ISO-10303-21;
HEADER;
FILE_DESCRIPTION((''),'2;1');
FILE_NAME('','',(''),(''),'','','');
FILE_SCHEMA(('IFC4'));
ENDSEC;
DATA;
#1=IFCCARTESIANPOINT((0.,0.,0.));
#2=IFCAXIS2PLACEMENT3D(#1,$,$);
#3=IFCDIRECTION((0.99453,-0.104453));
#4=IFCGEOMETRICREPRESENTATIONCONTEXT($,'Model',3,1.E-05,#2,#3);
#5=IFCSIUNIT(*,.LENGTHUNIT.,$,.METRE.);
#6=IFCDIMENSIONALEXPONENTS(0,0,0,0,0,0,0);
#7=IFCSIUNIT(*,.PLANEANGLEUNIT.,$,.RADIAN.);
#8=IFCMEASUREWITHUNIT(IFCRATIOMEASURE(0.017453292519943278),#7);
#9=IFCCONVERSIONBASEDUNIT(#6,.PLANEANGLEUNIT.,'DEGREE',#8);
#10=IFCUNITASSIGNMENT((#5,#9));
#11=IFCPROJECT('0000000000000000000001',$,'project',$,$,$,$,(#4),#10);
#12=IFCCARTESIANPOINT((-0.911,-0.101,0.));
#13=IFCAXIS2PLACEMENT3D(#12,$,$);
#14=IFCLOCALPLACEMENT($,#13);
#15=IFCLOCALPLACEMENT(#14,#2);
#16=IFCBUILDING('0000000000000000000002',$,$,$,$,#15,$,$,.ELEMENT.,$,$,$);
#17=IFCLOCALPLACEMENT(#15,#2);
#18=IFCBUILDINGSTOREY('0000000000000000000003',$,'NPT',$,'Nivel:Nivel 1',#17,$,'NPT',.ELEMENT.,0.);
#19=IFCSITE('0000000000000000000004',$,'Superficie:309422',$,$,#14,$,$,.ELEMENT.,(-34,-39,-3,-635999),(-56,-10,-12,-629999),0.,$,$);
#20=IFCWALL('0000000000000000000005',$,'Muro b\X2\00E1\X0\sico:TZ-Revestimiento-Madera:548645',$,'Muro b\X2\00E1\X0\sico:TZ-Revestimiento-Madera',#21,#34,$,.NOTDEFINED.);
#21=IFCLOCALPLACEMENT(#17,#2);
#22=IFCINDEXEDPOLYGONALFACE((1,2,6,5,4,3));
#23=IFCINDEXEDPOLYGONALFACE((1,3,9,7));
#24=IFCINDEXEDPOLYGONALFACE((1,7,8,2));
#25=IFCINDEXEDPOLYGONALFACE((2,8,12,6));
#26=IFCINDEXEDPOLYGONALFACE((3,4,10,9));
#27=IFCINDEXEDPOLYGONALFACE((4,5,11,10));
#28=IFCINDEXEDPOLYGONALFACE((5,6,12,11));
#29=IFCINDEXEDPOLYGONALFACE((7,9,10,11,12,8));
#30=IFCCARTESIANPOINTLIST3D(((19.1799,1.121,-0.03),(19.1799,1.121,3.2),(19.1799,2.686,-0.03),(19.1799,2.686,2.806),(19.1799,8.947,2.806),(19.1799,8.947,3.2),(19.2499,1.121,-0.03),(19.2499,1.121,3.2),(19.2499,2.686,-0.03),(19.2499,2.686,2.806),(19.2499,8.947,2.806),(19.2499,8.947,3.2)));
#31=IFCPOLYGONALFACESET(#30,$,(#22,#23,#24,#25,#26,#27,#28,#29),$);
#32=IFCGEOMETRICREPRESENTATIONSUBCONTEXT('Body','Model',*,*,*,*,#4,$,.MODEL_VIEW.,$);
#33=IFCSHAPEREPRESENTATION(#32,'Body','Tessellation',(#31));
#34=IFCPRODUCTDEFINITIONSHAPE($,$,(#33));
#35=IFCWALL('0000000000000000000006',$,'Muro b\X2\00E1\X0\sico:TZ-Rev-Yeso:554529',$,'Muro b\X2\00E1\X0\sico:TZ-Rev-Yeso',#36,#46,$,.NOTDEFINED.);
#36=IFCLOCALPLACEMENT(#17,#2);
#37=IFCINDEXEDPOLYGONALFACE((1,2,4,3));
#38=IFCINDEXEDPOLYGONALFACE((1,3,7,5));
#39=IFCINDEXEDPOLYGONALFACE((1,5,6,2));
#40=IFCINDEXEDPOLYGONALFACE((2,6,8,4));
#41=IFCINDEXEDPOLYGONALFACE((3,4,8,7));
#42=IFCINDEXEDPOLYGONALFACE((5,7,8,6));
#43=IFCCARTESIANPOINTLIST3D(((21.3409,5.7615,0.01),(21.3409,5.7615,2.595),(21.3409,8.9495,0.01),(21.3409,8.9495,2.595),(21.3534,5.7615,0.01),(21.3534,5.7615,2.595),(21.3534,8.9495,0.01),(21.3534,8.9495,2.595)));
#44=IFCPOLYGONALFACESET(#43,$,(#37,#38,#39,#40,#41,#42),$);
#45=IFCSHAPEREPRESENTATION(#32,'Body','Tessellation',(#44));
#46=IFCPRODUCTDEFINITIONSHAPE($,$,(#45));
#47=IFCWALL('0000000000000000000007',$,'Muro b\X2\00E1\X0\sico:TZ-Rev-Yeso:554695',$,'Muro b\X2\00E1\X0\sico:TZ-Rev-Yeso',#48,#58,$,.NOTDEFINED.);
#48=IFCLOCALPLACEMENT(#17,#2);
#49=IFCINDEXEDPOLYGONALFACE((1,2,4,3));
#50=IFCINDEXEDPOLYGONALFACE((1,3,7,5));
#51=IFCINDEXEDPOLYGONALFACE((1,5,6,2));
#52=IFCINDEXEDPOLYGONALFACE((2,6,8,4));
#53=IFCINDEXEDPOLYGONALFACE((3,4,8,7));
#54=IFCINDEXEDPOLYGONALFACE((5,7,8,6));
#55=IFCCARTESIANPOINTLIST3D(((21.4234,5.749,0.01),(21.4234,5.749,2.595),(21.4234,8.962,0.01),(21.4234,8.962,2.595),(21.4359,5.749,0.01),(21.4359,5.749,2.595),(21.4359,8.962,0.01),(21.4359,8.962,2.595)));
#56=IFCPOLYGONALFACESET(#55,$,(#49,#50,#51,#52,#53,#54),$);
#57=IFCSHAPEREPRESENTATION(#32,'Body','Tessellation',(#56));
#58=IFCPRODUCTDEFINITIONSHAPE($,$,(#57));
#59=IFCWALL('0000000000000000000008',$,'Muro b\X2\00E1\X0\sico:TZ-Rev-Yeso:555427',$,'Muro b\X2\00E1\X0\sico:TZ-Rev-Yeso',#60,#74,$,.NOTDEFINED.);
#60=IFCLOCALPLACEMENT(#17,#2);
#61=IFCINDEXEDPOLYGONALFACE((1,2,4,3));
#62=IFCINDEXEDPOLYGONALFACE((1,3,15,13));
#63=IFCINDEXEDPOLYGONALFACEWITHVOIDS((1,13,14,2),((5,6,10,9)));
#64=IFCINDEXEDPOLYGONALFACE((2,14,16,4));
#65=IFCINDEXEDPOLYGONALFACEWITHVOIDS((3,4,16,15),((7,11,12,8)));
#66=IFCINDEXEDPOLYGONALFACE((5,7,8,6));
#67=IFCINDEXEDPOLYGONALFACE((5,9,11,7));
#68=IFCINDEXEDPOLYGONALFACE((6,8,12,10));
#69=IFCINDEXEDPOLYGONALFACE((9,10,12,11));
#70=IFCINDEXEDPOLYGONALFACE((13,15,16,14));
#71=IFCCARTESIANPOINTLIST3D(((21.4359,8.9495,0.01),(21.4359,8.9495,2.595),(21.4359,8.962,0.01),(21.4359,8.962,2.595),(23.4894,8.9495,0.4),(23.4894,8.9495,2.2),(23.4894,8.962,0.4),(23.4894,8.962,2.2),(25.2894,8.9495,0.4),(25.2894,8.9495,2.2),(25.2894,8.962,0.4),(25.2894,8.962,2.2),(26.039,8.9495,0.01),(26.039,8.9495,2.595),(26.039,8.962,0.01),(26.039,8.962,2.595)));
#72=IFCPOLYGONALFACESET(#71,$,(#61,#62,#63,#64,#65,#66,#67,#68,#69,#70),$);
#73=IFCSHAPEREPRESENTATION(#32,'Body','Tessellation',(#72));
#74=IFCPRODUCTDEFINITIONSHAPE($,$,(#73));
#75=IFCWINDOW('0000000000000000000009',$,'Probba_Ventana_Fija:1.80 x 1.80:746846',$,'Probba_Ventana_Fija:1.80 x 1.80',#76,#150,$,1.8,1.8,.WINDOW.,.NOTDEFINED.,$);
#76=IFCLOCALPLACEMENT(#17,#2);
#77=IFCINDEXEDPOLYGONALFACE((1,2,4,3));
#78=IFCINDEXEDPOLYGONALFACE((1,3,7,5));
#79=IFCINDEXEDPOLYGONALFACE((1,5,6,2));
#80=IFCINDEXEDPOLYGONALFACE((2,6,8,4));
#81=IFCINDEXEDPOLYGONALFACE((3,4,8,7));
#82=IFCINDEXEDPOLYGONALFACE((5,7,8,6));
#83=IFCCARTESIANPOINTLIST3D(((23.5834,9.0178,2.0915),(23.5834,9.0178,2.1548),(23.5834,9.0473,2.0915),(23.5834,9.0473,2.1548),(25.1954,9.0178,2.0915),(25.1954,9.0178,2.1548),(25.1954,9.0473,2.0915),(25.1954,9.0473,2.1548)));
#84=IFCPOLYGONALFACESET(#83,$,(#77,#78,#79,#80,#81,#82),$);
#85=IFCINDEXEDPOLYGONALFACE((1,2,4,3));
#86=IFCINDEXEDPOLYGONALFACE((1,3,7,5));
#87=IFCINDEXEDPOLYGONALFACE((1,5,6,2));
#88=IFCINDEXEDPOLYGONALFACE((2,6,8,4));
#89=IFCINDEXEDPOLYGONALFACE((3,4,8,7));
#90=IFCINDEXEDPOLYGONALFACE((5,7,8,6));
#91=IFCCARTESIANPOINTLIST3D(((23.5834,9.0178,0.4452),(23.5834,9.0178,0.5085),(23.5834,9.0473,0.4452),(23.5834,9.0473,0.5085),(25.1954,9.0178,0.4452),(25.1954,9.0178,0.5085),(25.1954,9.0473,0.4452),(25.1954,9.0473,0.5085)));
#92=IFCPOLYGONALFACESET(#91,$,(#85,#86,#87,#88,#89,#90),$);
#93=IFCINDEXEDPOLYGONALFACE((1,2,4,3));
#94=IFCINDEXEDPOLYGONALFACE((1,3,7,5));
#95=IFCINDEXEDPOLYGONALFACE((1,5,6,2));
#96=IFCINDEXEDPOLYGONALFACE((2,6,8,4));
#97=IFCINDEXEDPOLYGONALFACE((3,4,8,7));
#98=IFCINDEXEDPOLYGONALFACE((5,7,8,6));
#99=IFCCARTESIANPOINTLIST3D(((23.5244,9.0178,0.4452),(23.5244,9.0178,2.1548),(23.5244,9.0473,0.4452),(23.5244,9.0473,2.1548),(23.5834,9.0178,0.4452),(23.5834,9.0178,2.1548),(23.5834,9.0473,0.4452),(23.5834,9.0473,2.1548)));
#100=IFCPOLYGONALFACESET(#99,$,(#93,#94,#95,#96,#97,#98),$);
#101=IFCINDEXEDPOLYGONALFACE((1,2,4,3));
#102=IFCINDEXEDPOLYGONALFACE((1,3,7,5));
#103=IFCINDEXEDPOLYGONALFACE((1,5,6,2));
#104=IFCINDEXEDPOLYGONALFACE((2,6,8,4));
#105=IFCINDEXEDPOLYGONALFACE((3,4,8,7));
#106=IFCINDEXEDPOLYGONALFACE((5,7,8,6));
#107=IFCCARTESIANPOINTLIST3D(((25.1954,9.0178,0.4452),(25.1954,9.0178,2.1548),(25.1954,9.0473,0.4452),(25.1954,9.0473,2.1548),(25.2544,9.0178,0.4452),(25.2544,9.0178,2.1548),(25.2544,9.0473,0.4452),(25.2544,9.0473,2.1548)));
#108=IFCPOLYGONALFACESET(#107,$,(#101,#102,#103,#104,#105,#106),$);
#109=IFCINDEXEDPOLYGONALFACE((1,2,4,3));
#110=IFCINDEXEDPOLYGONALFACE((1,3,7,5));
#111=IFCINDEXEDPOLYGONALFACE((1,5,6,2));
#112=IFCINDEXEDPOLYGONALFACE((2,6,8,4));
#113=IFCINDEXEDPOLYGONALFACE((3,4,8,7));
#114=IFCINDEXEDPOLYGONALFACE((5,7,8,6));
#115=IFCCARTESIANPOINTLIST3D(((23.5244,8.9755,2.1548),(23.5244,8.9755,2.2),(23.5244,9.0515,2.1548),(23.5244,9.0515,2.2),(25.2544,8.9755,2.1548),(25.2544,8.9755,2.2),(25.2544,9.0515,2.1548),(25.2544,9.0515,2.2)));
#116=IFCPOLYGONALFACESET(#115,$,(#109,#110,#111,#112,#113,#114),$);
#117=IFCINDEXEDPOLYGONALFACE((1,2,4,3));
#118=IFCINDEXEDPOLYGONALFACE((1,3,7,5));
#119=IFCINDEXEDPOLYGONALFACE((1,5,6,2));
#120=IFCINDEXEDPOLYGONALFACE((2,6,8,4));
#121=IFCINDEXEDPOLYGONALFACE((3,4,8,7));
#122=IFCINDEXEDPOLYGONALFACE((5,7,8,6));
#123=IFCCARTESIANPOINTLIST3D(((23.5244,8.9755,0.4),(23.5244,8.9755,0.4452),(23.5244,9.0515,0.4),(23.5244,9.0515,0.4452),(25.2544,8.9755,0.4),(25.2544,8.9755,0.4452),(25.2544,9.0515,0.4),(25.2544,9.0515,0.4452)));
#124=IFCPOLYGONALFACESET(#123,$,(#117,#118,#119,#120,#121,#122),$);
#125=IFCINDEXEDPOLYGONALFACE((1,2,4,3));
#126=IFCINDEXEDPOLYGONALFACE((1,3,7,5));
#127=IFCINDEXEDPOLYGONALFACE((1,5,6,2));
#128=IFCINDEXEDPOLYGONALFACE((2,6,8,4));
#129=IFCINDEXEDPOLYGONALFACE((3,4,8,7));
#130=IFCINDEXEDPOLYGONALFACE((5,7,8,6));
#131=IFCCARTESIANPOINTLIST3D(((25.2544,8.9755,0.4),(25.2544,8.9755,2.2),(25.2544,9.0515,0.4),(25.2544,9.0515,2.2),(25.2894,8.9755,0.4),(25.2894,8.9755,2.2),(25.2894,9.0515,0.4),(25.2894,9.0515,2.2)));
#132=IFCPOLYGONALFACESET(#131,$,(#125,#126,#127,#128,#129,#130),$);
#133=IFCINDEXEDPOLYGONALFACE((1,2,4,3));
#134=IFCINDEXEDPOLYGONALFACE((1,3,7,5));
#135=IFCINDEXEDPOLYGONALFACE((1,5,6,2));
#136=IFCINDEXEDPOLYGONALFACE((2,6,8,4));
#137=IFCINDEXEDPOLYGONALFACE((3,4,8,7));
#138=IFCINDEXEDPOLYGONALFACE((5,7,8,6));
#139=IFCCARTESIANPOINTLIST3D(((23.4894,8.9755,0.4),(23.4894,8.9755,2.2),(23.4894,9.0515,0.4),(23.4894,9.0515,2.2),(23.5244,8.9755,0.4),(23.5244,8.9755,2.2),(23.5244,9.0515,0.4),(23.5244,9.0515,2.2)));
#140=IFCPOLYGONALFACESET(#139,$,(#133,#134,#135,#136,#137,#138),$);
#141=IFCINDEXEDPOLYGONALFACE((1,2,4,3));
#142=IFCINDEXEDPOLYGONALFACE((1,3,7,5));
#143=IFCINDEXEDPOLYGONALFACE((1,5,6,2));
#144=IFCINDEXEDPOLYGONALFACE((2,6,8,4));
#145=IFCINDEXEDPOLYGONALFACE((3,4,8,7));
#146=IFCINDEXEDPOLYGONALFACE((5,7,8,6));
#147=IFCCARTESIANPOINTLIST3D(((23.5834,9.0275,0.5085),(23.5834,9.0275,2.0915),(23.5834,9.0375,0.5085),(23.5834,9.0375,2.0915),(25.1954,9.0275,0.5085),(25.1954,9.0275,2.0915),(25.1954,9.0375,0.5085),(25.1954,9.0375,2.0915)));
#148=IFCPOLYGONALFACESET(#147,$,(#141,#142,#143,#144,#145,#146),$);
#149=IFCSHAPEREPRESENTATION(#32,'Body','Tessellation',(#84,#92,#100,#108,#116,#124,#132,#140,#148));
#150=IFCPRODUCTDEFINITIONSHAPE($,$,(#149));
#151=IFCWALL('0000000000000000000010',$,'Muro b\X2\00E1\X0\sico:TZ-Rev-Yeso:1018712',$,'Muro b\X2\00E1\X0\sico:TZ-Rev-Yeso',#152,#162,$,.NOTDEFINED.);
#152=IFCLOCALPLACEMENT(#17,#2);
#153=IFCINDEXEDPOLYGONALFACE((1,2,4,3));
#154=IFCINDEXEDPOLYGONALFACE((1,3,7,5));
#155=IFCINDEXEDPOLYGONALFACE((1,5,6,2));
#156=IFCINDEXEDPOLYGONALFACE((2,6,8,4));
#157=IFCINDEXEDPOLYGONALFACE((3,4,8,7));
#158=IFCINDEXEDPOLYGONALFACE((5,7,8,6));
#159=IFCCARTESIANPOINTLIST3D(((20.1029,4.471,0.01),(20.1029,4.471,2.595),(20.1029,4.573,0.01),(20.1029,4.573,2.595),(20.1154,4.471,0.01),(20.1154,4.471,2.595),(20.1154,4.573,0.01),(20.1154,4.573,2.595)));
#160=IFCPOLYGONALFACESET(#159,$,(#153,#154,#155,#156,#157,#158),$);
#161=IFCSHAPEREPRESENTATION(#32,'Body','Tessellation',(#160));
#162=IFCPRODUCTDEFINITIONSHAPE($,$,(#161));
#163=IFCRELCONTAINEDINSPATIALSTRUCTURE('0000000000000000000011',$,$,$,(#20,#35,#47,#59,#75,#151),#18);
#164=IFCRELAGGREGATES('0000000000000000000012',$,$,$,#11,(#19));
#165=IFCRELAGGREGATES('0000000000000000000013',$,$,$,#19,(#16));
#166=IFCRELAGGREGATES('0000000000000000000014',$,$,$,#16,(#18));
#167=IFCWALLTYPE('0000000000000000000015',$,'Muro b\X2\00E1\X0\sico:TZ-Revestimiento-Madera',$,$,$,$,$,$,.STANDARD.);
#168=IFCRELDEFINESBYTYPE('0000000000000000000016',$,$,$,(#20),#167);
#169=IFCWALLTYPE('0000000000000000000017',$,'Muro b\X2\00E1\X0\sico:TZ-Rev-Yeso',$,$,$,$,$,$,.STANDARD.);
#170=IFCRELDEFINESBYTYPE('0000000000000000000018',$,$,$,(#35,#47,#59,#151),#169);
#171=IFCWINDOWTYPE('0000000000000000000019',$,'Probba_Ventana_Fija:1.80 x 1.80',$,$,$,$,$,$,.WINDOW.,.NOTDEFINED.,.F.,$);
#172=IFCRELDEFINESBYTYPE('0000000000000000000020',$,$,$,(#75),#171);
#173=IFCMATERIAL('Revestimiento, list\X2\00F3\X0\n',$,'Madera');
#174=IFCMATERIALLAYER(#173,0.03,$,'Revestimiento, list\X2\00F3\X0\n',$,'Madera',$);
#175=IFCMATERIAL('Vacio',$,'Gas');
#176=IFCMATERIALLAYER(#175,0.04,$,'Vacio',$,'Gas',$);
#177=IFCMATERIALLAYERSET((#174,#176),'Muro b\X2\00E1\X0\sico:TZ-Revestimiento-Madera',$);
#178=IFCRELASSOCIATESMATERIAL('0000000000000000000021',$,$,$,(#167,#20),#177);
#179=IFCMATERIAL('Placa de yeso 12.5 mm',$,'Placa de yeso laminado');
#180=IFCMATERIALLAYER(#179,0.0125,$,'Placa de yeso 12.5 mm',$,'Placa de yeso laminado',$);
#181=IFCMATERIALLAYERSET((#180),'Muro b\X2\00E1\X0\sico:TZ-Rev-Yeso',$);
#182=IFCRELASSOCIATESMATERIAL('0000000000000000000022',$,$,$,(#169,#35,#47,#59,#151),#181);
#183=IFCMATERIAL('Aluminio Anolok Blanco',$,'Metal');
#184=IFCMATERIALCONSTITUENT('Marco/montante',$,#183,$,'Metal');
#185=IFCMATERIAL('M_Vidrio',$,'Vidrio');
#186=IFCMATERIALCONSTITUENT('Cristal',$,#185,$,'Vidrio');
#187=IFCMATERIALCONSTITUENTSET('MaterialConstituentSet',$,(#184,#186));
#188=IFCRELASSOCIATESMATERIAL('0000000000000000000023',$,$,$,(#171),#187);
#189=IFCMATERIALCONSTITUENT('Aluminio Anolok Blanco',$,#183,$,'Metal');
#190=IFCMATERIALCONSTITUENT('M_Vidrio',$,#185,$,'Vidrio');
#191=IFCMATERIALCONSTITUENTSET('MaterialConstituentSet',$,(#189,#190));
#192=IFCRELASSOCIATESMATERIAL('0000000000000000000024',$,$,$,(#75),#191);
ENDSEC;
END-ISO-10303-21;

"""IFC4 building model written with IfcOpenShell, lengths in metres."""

from ifc_helpers import new_model, entity, si_unit, converted_unit, direction, frame, frame_2d, origin, origin_2d_with_axis, place, context, subcontext, project, spatial, rectangle, extrude, source, transform, mapped, material, layer, layer_set, layer_usage, constituent, constituent_set, type_object, type_shapes, element, fill, save


model = new_model("IFC4")

# Units and contexts
model_context = context("Model", 3, precision=1e-05, world=origin(), true_north=direction((0.99453, -0.104453)))
body_context = subcontext(model_context, "Body", "Model", "MODEL_VIEW")
ifc_project = project(units=[si_unit("LENGTHUNIT", "METRE"), converted_unit("PLANEANGLEUNIT", "DEGREE", entity("IfcRatioMeasure", 0.017453292519943278), si_unit("PLANEANGLEUNIT", "RADIAN"), dimensions=[0, 0, 0, 0, 0, 0, 0])], contexts=[model_context])

# Site, building, storey
site_placement = place(None, frame((-0.911, -0.101, 0.0)))
site = spatial("IfcSite", under=ifc_project, at=site_placement, Name="Superficie:309422", CompositionType="ELEMENT", RefLatitude=(-34, -39, -3, -635999), RefLongitude=(-56, -10, -12, -629999), RefElevation=0.0)
building_placement = place(site_placement, origin())
building = spatial("IfcBuilding", under=site, at=building_placement, CompositionType="ELEMENT")
storey_placement = place(building_placement, origin())
storey = spatial("IfcBuildingStorey", under=building, at=storey_placement, Name="NPT", ObjectType="Nivel:Nivel 1", LongName="NPT", CompositionType="ELEMENT", Elevation=0.0)

# Wall, opening
ifc_material_1 = material(Name="Revestimiento, listón", Category="Madera")
ifc_layer_1 = layer(ifc_material_1, 0.03, Name="Revestimiento, listón", Category="Madera")
ifc_material_2 = material(Name="Vacio", Category="Gas")
ifc_layer_2 = layer(ifc_material_2, 0.04, Name="Vacio", Category="Gas")
ifc_layer_set_1 = layer_set([ifc_layer_1, ifc_layer_2], Name="Muro básico:TZ-Revestimiento-Madera")
ifc_layer_usage_1 = layer_usage(ifc_layer_set_1, "AXIS2", "NEGATIVE", 0.035)
wall_type_1 = type_object("IfcWallType", Name="Muro básico:TZ-Revestimiento-Madera", PredefinedType="STANDARD", material=ifc_layer_set_1)
wall_1_placement = place(storey_placement, frame((19.2149, 8.947, -0.03), z_axis=(0.0, 0.0, 1.0), x_axis=(0.0, -1.0, 0.0)))
wall_1 = element("IfcWall", 1, at=wall_1_placement, inside=storey, type_object=wall_type_1, material=ifc_layer_usage_1, Name="Muro básico:TZ-Revestimiento-Madera:548645", ObjectType="Muro básico:TZ-Revestimiento-Madera", PredefinedType="NOTDEFINED", context=body_context, shape_type="SweptSolid", body=[
    extrude(rectangle(XDim=7.826, YDim=0.07, at=frame_2d((3.913, 0.0), x_axis=(-1.0, 0.0))), origin(), (0.0, 0.0, 1.0), 3.23),
])
opening_1_placement = place(wall_1_placement, origin())
element("IfcOpeningElement", 2, at=opening_1_placement, cuts=wall_1, PredefinedType="OPENING", context=body_context, shape_type="SweptSolid", body=[
    extrude(rectangle(XDim=2.836, YDim=6.2685, at=frame_2d((0.0, 0.0), x_axis=(1.0, 0.0))), frame((3.1268, 0.035, 1.418), z_axis=(0.0, -1.0, 0.0), x_axis=(0.0, 0.0, -1.0)), (0.0, 0.0, 1.0), 0.07),
])

# Walls
ifc_material_3 = material(Name="Placa de yeso 12.5 mm", Category="Placa de yeso laminado")
ifc_layer_3 = layer(ifc_material_3, 0.0125, Name="Placa de yeso 12.5 mm", Category="Placa de yeso laminado")
ifc_layer_set_2 = layer_set([ifc_layer_3], Name="Muro básico:TZ-Rev-Yeso")
ifc_layer_usage_2 = layer_usage(ifc_layer_set_2, "AXIS2", "POSITIVE", -0.0063)
wall_type_2 = type_object("IfcWallType", Name="Muro básico:TZ-Rev-Yeso", PredefinedType="STANDARD", material=ifc_layer_set_2)
wall_2_placement = place(storey_placement, frame((21.3471, 5.7615, 0.01), z_axis=(0.0, 0.0, 1.0), x_axis=(0.0, 1.0, 0.0)))
element("IfcWall", 3, at=wall_2_placement, inside=storey, type_object=wall_type_2, material=ifc_layer_usage_2, Name="Muro básico:TZ-Rev-Yeso:554529", ObjectType="Muro básico:TZ-Rev-Yeso", PredefinedType="NOTDEFINED", context=body_context, shape_type="SweptSolid", body=[
    extrude(rectangle(XDim=3.188, YDim=0.0125, at=frame_2d((1.594, 0.0), x_axis=(-1.0, 0.0))), origin(), (0.0, 0.0, 1.0), 2.585),
])
ifc_layer_usage_3 = layer_usage(ifc_layer_set_2, "AXIS2", "POSITIVE", -0.0063)
wall_3_placement = place(storey_placement, frame((21.4296, 8.962, 0.01), z_axis=(0.0, 0.0, 1.0), x_axis=(0.0, -1.0, 0.0)))
element("IfcWall", 4, at=wall_3_placement, inside=storey, type_object=wall_type_2, material=ifc_layer_usage_3, Name="Muro básico:TZ-Rev-Yeso:554695", ObjectType="Muro básico:TZ-Rev-Yeso", PredefinedType="NOTDEFINED", context=body_context, shape_type="SweptSolid", body=[
    extrude(rectangle(XDim=3.213, YDim=0.0125, at=frame_2d((1.6065, 0.0), x_axis=(-1.0, 0.0))), origin(), (0.0, 0.0, 1.0), 2.585),
])

# Wall, opening, window
ifc_layer_usage_4 = layer_usage(ifc_layer_set_2, "AXIS2", "NEGATIVE", 0.0063)
wall_4_placement = place(storey_placement, frame((21.4359, 8.9558, 0.01)))
wall_4 = element("IfcWall", 5, at=wall_4_placement, inside=storey, type_object=wall_type_2, material=ifc_layer_usage_4, Name="Muro básico:TZ-Rev-Yeso:555427", ObjectType="Muro básico:TZ-Rev-Yeso", PredefinedType="NOTDEFINED", context=body_context, shape_type="SweptSolid", body=[
    extrude(rectangle(XDim=4.6031, YDim=0.0125, at=frame_2d((2.3015, 0.0), x_axis=(-1.0, 0.0))), origin(), (0.0, 0.0, 1.0), 2.585),
])
opening_2_placement = place(wall_4_placement, frame((3.8535, 0.0063, 0.39)))
opening_2 = element("IfcOpeningElement", 6, at=opening_2_placement, cuts=wall_4, PredefinedType="OPENING", context=body_context, shape_type="SweptSolid", body=[
    extrude(rectangle(XDim=1.8, YDim=1.8, at=frame_2d((0.9, 0.9), x_axis=(1.0, 0.0))), frame((0.0, 0.0, 0.0), z_axis=(0.0, -1.0, 0.0), x_axis=(0.0, 0.0, 1.0)), (0.0, 0.0, 1.0), 0.0125),
])
ifc_material_4 = material(Name="Aluminio Anolok Blanco", Category="Metal")
ifc_constituent_1 = constituent(ifc_material_4, Name="Aluminio Anolok Blanco", Category="Metal")
ifc_material_5 = material(Name="M_Vidrio", Category="Vidrio")
ifc_constituent_2 = constituent(ifc_material_5, Name="M_Vidrio", Category="Vidrio")
ifc_constituent_set_1 = constituent_set(constituents=[ifc_constituent_1, ifc_constituent_2], Name="MaterialConstituentSet")
ifc_constituent_3 = constituent(ifc_material_4, Name="Marco/montante", Category="Metal")
ifc_constituent_4 = constituent(ifc_material_5, Name="Cristal", Category="Vidrio")
ifc_constituent_set_2 = constituent_set(constituents=[ifc_constituent_3, ifc_constituent_4], Name="MaterialConstituentSet")
window_type = type_object("IfcWindowType", Name="Probba_Ventana_Fija:1.80 x 1.80", ParameterTakesPrecedence=False, PartitioningType="NOTDEFINED", PredefinedType="WINDOW", material=ifc_constituent_set_2)
shared_shape_1 = source(origin(), body_context, "Body", "SweptSolid", [
    extrude(rectangle(XDim=1.612, YDim=0.0295, at=origin_2d_with_axis()), frame((0.9, -0.0705, 1.6915)), (0.0, 0.0, 1.0), 0.0633),
    extrude(rectangle(XDim=1.612, YDim=0.0295, at=origin_2d_with_axis()), frame((0.9, -0.0705, 0.0452)), (0.0, 0.0, 1.0), 0.0633),
    extrude(rectangle(XDim=0.0295, YDim=0.059, at=origin_2d_with_axis()), frame((1.7355, -0.0705, 0.0452), z_axis=(0.0, 0.0, 1.0), x_axis=(0.0, 1.0, 0.0)), (0.0, 0.0, 1.0), 1.7096),
    extrude(rectangle(XDim=0.0295, YDim=0.059, at=frame_2d((0.0, 0.0), x_axis=(1.0, 0.0))), frame((0.0645, -0.0705, 0.0452), z_axis=(0.0, 0.0, 1.0), x_axis=(0.0, 1.0, 0.0)), (0.0, 0.0, 1.0), 1.7096),
    extrude(rectangle(XDim=1.73, YDim=0.076, at=origin_2d_with_axis()), frame((0.9, -0.0515, 1.7548)), (0.0, 0.0, 1.0), 0.0452),
    extrude(rectangle(XDim=1.73, YDim=0.076, at=frame_2d((0.0, 0.0), x_axis=(1.0, 0.0))), frame((0.9, -0.0515, 0.0)), (0.0, 0.0, 1.0), 0.0452),
    extrude(rectangle(XDim=0.035, YDim=0.076, at=origin_2d_with_axis()), frame((0.0175, -0.0515, 0.0), z_axis=(0.0, 0.0, 1.0), x_axis=(-1.0, 0.0, 0.0)), (0.0, 0.0, 1.0), 1.8),
    extrude(rectangle(XDim=0.035, YDim=0.076, at=origin_2d_with_axis()), frame((1.7825, -0.0515, 0.0), z_axis=(0.0, 0.0, 1.0), x_axis=(-1.0, 0.0, 0.0)), (0.0, 0.0, 1.0), 1.8),
    extrude(rectangle(XDim=0.01, YDim=1.612, at=origin_2d_with_axis()), frame((0.9, -0.0705, 0.1085), z_axis=(0.0, 0.0, 1.0), x_axis=(0.0, 1.0, 0.0)), (0.0, 0.0, 1.0), 1.583),
])
type_shapes(window_type, [shared_shape_1])
window_placement = place(opening_2_placement, frame((0.0, 0.0, 0.0), z_axis=(0.0, 0.0, 1.0), x_axis=(-1.0, 0.0, 0.0)))
window = element("IfcWindow", 7, at=window_placement, inside=storey, type_object=window_type, material=ifc_constituent_set_1, Name="Probba_Ventana_Fija:1.80 x 1.80:746846", ObjectType="Probba_Ventana_Fija:1.80 x 1.80", OverallHeight=1.8, OverallWidth=1.8, PartitioningType="NOTDEFINED", PredefinedType="WINDOW", context=body_context, shape_type="MappedRepresentation", body=[
    mapped(shared_shape_1, transform((0.0, 0.0, 0.0), scale=1.0)),
])
fill(opening_2, window)

# Wall
ifc_layer_usage_5 = layer_usage(ifc_layer_set_2, "AXIS2", "NEGATIVE", 0.0063)
wall_5_placement = place(storey_placement, frame((20.1092, 4.573, 0.01), z_axis=(0.0, 0.0, 1.0), x_axis=(0.0, -1.0, 0.0)))
element("IfcWall", 8, at=wall_5_placement, inside=storey, type_object=wall_type_2, material=ifc_layer_usage_5, Name="Muro básico:TZ-Rev-Yeso:1018712", ObjectType="Muro básico:TZ-Rev-Yeso", PredefinedType="NOTDEFINED", context=body_context, shape_type="SweptSolid", body=[
    extrude(rectangle(XDim=0.102, YDim=0.0125, at=frame_2d((0.051, 0.0), x_axis=(-1.0, 0.0))), origin(), (0.0, 0.0, 1.0), 2.585),
])

save(model, "model.ifc")
